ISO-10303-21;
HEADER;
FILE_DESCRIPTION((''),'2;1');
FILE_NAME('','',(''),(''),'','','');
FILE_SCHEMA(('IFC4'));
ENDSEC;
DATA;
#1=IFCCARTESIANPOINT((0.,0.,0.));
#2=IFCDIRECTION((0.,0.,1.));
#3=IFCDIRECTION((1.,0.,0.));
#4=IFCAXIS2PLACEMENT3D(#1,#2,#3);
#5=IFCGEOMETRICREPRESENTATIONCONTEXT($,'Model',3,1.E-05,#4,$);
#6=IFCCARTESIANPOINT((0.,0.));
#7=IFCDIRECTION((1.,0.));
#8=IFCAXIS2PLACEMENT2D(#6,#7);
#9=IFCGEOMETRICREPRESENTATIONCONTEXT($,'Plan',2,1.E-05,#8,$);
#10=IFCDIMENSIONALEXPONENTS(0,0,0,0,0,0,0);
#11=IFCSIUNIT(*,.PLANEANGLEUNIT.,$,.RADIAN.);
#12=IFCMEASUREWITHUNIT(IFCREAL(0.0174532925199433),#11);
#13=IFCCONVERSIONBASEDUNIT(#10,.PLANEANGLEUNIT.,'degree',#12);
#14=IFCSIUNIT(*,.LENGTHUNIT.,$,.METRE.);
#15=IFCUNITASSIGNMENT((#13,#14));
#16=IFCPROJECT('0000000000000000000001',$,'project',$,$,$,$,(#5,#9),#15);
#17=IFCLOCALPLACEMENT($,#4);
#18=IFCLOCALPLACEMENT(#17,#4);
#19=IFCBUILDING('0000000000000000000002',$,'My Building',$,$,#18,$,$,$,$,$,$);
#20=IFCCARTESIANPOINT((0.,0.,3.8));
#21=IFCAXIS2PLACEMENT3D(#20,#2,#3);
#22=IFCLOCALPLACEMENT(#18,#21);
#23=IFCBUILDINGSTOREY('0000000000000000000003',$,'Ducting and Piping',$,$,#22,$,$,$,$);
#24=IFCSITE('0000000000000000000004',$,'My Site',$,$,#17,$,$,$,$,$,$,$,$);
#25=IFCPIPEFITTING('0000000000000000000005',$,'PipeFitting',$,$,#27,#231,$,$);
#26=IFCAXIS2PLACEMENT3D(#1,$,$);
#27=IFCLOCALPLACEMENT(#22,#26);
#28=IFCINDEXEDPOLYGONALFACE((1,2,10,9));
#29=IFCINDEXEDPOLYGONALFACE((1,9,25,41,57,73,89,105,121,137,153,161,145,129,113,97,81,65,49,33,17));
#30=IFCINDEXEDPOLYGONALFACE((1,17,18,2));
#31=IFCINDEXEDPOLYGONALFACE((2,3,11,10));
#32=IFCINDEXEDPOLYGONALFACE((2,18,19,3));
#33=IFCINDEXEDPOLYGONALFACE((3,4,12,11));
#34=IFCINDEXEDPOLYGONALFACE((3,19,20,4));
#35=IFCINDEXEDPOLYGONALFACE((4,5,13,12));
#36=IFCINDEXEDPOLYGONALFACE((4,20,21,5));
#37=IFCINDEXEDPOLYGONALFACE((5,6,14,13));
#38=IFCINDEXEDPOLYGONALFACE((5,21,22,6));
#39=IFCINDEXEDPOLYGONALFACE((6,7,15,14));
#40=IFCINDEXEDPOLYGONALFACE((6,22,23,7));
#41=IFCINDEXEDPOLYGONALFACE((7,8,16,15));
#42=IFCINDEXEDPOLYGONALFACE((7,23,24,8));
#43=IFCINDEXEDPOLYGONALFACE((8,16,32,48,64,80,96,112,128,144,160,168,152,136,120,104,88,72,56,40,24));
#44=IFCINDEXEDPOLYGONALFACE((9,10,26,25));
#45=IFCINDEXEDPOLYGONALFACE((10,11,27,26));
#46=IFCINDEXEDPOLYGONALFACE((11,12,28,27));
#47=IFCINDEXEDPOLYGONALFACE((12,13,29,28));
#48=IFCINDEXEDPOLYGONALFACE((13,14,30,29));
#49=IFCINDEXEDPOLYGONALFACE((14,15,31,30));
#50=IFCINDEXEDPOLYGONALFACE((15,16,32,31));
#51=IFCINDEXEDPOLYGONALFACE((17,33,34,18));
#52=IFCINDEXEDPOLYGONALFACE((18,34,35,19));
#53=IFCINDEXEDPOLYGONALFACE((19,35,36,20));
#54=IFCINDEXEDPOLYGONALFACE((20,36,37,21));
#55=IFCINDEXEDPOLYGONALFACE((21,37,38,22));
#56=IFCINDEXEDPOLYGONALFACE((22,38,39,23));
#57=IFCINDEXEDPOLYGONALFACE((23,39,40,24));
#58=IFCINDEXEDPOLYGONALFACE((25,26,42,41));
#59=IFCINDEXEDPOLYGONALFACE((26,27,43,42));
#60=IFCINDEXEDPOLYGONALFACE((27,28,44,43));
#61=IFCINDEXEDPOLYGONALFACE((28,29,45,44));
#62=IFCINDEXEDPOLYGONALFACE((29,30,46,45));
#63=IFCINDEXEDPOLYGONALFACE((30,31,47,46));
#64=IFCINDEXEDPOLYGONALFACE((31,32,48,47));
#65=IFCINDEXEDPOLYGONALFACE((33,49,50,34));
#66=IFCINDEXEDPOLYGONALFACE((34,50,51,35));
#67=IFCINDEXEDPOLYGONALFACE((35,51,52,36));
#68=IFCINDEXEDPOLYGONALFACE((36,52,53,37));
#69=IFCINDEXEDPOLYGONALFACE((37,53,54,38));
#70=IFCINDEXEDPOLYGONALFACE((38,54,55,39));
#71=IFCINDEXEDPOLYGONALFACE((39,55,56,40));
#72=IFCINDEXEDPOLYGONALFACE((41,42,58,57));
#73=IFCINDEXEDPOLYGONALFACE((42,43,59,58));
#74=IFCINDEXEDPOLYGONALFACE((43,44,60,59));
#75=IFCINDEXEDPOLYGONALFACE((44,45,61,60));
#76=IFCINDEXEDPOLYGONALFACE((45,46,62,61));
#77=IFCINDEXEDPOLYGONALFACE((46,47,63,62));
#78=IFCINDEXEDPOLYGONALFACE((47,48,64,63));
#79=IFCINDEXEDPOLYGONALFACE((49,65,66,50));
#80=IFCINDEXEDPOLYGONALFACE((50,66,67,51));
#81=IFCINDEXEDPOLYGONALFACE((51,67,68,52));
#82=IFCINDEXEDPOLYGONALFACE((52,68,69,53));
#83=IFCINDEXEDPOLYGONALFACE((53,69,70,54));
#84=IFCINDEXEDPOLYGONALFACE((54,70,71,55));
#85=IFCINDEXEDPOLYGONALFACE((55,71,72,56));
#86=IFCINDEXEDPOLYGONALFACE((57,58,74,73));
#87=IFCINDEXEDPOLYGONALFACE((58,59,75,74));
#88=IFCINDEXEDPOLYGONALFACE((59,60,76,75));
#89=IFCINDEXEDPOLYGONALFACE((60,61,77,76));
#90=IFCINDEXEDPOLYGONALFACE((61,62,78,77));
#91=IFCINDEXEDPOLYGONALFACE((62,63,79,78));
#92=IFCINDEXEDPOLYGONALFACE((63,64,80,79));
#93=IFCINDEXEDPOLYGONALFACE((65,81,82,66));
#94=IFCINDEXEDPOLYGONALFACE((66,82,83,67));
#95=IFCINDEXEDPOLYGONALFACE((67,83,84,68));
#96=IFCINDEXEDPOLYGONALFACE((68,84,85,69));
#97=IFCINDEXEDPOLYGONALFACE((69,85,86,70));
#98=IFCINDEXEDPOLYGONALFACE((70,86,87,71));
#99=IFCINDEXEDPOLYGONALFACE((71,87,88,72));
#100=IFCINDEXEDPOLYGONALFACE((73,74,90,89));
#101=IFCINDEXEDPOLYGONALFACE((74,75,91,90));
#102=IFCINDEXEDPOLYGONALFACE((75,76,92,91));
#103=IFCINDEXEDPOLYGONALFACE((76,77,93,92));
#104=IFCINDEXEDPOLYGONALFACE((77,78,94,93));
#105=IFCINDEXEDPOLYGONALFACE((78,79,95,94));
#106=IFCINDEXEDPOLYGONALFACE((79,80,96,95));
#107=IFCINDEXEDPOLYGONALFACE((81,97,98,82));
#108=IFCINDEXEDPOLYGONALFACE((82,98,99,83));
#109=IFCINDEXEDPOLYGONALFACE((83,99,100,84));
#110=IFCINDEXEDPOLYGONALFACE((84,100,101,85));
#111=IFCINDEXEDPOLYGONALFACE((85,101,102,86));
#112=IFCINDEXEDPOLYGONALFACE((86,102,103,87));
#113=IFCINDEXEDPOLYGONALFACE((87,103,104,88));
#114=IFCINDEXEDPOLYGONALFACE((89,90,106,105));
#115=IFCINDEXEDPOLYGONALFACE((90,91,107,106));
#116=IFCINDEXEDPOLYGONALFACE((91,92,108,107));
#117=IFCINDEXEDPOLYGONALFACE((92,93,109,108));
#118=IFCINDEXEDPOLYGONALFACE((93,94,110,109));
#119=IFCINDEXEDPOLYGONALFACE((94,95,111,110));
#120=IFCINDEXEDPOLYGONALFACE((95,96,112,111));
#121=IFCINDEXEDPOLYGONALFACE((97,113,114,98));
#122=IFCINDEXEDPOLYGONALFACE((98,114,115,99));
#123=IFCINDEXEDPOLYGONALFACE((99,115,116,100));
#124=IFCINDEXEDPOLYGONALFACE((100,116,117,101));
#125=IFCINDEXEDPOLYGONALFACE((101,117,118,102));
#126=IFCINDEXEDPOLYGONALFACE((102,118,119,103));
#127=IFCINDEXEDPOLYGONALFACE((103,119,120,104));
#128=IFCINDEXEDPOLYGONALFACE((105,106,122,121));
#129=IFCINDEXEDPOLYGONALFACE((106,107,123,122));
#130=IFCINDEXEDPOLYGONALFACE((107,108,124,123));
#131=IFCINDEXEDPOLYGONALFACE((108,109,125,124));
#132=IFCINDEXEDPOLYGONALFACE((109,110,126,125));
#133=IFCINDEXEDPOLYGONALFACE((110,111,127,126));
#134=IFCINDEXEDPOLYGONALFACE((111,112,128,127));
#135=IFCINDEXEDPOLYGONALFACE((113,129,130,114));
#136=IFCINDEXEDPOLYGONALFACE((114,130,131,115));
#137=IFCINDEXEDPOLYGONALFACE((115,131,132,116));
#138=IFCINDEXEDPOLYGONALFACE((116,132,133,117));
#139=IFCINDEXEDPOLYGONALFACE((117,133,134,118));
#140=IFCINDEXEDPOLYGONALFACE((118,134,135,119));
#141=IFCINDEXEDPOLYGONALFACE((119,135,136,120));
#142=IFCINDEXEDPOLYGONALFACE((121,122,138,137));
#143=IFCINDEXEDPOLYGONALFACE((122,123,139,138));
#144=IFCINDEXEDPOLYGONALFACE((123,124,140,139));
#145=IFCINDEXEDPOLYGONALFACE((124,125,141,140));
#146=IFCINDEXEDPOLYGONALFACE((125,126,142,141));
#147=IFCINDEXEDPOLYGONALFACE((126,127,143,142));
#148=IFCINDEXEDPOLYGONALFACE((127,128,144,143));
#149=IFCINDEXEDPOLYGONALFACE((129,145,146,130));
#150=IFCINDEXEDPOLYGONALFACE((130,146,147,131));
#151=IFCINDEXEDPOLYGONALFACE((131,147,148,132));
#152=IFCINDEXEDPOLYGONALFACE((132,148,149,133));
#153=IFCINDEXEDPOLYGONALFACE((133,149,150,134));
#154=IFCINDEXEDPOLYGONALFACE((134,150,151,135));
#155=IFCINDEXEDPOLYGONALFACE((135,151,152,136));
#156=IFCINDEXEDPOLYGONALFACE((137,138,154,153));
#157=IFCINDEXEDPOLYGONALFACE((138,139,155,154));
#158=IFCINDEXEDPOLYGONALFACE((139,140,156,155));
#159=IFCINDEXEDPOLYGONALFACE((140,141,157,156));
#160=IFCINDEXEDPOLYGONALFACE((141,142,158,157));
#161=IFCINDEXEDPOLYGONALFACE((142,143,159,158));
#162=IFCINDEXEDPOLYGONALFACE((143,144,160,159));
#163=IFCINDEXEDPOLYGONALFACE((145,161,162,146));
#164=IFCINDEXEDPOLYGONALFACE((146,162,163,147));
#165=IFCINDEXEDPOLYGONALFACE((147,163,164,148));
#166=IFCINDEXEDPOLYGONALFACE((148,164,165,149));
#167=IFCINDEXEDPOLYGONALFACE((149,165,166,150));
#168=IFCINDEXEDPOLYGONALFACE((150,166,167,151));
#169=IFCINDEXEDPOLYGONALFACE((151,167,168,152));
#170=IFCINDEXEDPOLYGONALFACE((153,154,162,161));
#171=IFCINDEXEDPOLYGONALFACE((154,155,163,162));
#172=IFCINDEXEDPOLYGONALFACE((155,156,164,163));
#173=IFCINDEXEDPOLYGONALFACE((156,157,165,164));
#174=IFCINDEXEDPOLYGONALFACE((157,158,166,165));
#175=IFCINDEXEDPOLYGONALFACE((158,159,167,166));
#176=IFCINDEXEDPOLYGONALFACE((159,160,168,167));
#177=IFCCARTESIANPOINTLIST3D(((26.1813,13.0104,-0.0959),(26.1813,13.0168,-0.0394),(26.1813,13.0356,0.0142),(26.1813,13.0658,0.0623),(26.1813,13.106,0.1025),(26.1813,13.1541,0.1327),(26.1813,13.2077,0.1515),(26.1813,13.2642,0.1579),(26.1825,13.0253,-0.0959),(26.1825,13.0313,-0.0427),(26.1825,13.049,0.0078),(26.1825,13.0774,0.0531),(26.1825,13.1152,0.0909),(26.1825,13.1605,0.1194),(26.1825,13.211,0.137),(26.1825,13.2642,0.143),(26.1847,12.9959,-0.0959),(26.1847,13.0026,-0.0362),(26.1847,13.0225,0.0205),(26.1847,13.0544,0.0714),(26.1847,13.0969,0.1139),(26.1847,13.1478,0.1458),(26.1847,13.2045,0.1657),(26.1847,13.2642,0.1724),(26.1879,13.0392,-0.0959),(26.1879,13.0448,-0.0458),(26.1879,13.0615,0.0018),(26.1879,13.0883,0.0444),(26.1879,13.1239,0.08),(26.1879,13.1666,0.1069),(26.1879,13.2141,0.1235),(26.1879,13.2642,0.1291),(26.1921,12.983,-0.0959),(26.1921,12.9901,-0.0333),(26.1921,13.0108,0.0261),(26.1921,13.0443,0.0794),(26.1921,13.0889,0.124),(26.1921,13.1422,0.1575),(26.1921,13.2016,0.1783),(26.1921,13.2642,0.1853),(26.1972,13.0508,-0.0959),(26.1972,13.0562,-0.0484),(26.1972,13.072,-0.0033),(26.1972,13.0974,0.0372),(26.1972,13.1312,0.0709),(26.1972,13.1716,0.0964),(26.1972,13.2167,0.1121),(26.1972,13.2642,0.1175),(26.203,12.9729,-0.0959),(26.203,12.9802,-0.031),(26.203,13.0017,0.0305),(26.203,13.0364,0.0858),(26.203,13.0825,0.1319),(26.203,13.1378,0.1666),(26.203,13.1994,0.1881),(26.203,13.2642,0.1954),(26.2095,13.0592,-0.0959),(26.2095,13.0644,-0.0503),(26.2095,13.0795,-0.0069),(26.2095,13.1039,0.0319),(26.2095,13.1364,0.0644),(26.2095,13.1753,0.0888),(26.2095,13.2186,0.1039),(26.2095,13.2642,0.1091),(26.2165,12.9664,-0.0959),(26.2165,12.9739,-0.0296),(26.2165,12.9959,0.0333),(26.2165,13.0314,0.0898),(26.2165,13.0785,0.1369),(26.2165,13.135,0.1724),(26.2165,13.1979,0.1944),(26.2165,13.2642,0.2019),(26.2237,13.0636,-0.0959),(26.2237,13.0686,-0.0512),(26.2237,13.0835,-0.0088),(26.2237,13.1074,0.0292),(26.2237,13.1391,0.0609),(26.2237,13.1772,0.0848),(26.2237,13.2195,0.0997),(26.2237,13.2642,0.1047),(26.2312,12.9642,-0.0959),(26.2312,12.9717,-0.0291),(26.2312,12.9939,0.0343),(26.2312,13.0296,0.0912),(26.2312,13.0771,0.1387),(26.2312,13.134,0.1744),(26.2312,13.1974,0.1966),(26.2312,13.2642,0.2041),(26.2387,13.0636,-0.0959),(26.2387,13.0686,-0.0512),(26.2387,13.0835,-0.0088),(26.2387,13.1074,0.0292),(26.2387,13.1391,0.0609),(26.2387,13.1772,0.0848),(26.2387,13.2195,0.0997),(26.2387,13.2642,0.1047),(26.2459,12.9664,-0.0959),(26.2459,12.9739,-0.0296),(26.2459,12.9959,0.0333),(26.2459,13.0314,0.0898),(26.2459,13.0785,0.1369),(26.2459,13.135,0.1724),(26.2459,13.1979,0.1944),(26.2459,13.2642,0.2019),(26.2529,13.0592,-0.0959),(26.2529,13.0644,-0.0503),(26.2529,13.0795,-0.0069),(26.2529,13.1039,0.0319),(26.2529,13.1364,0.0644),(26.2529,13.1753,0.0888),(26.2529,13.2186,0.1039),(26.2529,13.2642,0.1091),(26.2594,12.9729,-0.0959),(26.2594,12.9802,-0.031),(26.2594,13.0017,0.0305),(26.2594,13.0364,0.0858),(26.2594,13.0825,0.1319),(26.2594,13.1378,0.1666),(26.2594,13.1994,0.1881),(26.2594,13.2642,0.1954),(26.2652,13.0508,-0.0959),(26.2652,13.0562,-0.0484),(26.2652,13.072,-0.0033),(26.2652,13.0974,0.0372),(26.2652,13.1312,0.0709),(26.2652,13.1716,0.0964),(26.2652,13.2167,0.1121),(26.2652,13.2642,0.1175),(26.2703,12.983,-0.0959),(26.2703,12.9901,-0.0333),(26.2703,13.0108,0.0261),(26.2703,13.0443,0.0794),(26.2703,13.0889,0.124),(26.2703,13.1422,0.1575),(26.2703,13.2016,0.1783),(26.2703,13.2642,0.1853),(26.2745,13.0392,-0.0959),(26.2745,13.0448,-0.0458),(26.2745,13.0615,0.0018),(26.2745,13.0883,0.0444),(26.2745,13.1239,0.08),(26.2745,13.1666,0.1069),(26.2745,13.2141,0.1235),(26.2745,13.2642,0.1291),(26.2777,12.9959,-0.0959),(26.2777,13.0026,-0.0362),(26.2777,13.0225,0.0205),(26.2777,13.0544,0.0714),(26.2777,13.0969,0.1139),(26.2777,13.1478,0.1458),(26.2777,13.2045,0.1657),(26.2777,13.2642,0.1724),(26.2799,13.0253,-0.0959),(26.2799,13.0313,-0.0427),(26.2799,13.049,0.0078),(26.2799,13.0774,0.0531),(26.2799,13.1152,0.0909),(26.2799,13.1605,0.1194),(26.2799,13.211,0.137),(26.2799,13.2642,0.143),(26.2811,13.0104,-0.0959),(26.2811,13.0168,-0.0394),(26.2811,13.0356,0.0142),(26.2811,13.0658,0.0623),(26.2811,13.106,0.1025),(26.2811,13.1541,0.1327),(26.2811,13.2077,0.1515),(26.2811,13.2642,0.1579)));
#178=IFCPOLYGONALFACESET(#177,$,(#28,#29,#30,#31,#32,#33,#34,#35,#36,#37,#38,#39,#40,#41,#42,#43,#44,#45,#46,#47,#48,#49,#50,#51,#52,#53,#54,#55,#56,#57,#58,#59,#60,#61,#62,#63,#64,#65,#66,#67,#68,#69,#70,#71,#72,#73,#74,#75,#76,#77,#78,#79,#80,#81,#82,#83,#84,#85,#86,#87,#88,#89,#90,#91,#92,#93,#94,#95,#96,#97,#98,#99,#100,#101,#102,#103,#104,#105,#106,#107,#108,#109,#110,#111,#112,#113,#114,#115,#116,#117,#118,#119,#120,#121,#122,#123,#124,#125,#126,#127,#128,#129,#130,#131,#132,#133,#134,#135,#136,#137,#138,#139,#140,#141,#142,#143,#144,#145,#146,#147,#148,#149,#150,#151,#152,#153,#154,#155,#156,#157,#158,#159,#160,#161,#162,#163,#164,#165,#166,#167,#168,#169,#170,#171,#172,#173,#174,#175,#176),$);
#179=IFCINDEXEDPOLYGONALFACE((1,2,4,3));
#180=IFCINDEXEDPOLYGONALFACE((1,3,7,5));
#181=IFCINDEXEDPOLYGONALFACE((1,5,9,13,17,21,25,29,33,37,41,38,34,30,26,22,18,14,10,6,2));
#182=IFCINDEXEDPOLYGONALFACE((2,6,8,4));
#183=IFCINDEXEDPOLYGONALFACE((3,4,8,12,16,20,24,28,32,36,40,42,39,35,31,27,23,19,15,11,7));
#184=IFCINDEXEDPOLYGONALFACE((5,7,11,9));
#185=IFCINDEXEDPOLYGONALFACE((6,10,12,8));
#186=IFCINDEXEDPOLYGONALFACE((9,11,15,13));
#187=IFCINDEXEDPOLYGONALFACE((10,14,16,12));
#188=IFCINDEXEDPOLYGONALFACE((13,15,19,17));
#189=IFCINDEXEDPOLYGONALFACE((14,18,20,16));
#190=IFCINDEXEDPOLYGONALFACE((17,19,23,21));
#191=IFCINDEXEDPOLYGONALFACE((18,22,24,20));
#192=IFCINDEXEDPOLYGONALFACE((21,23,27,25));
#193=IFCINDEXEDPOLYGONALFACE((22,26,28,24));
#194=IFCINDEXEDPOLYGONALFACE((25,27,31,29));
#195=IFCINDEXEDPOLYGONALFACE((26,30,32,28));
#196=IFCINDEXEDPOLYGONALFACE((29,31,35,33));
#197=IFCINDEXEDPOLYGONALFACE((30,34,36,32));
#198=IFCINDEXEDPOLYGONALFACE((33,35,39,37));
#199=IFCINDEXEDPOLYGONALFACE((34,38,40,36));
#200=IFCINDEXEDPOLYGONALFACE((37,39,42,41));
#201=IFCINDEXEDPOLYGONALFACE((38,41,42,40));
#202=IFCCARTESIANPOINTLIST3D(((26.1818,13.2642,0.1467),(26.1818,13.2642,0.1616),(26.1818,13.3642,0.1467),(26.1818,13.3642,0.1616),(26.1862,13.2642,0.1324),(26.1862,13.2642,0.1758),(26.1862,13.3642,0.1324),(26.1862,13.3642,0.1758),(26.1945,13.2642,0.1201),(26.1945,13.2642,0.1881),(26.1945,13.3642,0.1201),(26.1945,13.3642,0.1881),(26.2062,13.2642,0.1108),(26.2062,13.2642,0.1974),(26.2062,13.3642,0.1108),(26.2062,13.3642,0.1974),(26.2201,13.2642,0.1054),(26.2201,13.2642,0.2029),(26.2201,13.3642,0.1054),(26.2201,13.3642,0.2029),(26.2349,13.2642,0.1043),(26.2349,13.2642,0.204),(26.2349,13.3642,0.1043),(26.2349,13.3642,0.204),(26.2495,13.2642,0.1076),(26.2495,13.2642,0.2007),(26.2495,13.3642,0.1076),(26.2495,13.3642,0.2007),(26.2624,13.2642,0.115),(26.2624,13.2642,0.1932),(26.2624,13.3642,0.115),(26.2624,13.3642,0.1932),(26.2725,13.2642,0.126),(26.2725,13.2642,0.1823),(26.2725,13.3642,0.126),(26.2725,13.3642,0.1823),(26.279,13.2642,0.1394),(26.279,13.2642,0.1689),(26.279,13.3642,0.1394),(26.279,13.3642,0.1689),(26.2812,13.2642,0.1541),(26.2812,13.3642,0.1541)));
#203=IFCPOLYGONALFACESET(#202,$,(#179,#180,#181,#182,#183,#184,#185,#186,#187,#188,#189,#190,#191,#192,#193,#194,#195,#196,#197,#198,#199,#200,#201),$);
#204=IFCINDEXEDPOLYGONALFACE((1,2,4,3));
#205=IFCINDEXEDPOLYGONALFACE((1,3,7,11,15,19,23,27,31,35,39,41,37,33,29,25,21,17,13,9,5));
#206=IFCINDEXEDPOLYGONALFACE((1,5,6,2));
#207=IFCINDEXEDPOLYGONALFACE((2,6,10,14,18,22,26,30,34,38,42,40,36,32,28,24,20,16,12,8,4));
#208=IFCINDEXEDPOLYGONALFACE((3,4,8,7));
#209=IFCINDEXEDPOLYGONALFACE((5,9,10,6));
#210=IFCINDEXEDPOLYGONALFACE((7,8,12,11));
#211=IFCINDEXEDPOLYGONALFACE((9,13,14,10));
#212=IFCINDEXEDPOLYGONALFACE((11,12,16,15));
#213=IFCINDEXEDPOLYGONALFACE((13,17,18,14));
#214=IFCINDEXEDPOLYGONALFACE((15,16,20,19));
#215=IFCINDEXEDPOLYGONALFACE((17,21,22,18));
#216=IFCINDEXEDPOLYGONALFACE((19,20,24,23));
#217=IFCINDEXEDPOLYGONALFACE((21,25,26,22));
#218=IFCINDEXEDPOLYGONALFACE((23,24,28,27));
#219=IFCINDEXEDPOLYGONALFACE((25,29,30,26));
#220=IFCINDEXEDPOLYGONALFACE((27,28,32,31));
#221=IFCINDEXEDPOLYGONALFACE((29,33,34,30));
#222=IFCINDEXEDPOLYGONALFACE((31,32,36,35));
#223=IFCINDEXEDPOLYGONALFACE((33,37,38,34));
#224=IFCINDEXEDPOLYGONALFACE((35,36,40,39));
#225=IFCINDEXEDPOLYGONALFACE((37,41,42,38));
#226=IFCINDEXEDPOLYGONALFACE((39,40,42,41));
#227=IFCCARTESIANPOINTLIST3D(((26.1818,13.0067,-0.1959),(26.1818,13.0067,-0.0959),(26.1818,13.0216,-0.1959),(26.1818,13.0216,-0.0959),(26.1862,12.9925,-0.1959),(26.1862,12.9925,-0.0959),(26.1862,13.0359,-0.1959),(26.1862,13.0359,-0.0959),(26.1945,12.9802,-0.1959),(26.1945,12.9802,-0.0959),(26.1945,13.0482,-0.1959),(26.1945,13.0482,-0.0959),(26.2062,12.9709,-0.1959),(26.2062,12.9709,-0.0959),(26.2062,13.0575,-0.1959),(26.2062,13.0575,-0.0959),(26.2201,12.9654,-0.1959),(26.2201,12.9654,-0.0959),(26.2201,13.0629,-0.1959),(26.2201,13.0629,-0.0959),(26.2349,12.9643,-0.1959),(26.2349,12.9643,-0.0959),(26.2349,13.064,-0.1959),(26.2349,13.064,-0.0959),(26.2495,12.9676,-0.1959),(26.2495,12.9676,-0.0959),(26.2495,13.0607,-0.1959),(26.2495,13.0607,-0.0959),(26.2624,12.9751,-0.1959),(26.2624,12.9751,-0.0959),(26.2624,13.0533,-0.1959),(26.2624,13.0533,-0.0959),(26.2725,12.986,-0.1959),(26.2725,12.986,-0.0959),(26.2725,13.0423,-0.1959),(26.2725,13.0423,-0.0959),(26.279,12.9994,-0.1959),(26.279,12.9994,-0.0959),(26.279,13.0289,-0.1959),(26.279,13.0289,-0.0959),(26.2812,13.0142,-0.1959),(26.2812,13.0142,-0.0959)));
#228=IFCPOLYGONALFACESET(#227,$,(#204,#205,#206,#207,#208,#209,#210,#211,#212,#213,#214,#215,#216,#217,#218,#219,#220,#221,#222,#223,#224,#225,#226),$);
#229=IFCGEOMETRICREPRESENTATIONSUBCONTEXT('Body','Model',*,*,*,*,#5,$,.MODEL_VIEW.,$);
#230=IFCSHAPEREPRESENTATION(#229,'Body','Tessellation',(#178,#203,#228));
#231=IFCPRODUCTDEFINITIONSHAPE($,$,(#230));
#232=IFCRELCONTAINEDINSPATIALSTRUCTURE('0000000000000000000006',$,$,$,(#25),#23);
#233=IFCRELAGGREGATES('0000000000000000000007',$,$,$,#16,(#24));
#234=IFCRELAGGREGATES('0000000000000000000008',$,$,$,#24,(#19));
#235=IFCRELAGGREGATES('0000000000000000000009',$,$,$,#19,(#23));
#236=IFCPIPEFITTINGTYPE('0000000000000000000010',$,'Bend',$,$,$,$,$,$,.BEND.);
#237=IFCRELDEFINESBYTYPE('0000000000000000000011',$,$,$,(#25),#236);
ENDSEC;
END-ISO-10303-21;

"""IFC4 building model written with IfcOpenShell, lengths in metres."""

from ifc_helpers import new_model, entity, si_unit, converted_unit, frame, origin_with_axes, origin_2d_with_axis, place, context, subcontext, project, spatial, circle, extrude, source, transform, mapped, type_object, type_shapes, element, save


model = new_model("IFC4")

# Units and contexts
model_context = context("Model", 3, precision=1e-05, world=origin_with_axes())
plan_context = context("Plan", 2, precision=1e-05, world=origin_2d_with_axis())
body_context = subcontext(model_context, "Body", "Model", "MODEL_VIEW")
ifc_project = project(units=[converted_unit("PLANEANGLEUNIT", "degree", entity("IfcReal", 0.0174532925199433), si_unit("PLANEANGLEUNIT", "RADIAN"), dimensions=[0, 0, 0, 0, 0, 0, 0]), si_unit("LENGTHUNIT", "METRE")], contexts=[model_context, plan_context])

# Site, building, storey
site_placement = place(None, origin_with_axes())
site = spatial("IfcSite", under=ifc_project, at=site_placement, Name="My Site")
building_placement = place(site_placement, origin_with_axes())
building = spatial("IfcBuilding", under=site, at=building_placement, Name="My Building")
storey_placement = place(building_placement, frame((0.0, 0.0, 3.8), z_axis=(0.0, 0.0, 1.0), x_axis=(1.0, 0.0, 0.0)))
storey = spatial("IfcBuildingStorey", under=building, at=storey_placement, Name="Ducting and Piping")

# Pipe fitting
pipe_fitting_type = type_object("IfcPipeFittingType", Name="Bend", PredefinedType="BEND")
shared_shape = source(origin_with_axes(), body_context, "Body", "SolidModel", [
    entity("IfcSweptDiskSolid", entity("IfcIndexedPolyCurve", entity("IfcCartesianPointList3D", [[0.0, 0.0, 0.1], [0.0, -0.0732, 0.2768], [0.0, -0.25, 0.35]]), [entity("IfcArcIndex", [1, 2, 3])]), 0.05),
    extrude(circle(Radius=0.05), origin_with_axes(), (0.0, 0.0, 1.0), 0.1),
    extrude(circle(Radius=0.05), frame((0.0, -0.25, 0.35), z_axis=(0.0, -1.0, 0.0), x_axis=(1.0, 0.0, 0.0)), (0.0, 0.0, 1.0), 0.1),
])
type_shapes(pipe_fitting_type, [shared_shape])
for number, where, z_axis, x_axis, name in (
    (1, (26.2312, 13.3642, 0.1541), (0.0, -1.0, 0.0), (1.0, 0.0, 0.0), "PipeFitting"),
):
    element("IfcPipeFitting", number, at=place(storey_placement, frame(where, z_axis=z_axis, x_axis=x_axis)), inside=storey, type_object=pipe_fitting_type, Name=name, context=body_context, shape_type="MappedRepresentation", body=[
        mapped(shared_shape, transform((0.0, 0.0, 0.0), x_axis=(1.0, 0.0, 0.0), y_axis=(0.0, 1.0, 0.0), z_axis=(0.0, 0.0, 1.0), scale=1.0)),
    ])

save(model, "model.ifc")
